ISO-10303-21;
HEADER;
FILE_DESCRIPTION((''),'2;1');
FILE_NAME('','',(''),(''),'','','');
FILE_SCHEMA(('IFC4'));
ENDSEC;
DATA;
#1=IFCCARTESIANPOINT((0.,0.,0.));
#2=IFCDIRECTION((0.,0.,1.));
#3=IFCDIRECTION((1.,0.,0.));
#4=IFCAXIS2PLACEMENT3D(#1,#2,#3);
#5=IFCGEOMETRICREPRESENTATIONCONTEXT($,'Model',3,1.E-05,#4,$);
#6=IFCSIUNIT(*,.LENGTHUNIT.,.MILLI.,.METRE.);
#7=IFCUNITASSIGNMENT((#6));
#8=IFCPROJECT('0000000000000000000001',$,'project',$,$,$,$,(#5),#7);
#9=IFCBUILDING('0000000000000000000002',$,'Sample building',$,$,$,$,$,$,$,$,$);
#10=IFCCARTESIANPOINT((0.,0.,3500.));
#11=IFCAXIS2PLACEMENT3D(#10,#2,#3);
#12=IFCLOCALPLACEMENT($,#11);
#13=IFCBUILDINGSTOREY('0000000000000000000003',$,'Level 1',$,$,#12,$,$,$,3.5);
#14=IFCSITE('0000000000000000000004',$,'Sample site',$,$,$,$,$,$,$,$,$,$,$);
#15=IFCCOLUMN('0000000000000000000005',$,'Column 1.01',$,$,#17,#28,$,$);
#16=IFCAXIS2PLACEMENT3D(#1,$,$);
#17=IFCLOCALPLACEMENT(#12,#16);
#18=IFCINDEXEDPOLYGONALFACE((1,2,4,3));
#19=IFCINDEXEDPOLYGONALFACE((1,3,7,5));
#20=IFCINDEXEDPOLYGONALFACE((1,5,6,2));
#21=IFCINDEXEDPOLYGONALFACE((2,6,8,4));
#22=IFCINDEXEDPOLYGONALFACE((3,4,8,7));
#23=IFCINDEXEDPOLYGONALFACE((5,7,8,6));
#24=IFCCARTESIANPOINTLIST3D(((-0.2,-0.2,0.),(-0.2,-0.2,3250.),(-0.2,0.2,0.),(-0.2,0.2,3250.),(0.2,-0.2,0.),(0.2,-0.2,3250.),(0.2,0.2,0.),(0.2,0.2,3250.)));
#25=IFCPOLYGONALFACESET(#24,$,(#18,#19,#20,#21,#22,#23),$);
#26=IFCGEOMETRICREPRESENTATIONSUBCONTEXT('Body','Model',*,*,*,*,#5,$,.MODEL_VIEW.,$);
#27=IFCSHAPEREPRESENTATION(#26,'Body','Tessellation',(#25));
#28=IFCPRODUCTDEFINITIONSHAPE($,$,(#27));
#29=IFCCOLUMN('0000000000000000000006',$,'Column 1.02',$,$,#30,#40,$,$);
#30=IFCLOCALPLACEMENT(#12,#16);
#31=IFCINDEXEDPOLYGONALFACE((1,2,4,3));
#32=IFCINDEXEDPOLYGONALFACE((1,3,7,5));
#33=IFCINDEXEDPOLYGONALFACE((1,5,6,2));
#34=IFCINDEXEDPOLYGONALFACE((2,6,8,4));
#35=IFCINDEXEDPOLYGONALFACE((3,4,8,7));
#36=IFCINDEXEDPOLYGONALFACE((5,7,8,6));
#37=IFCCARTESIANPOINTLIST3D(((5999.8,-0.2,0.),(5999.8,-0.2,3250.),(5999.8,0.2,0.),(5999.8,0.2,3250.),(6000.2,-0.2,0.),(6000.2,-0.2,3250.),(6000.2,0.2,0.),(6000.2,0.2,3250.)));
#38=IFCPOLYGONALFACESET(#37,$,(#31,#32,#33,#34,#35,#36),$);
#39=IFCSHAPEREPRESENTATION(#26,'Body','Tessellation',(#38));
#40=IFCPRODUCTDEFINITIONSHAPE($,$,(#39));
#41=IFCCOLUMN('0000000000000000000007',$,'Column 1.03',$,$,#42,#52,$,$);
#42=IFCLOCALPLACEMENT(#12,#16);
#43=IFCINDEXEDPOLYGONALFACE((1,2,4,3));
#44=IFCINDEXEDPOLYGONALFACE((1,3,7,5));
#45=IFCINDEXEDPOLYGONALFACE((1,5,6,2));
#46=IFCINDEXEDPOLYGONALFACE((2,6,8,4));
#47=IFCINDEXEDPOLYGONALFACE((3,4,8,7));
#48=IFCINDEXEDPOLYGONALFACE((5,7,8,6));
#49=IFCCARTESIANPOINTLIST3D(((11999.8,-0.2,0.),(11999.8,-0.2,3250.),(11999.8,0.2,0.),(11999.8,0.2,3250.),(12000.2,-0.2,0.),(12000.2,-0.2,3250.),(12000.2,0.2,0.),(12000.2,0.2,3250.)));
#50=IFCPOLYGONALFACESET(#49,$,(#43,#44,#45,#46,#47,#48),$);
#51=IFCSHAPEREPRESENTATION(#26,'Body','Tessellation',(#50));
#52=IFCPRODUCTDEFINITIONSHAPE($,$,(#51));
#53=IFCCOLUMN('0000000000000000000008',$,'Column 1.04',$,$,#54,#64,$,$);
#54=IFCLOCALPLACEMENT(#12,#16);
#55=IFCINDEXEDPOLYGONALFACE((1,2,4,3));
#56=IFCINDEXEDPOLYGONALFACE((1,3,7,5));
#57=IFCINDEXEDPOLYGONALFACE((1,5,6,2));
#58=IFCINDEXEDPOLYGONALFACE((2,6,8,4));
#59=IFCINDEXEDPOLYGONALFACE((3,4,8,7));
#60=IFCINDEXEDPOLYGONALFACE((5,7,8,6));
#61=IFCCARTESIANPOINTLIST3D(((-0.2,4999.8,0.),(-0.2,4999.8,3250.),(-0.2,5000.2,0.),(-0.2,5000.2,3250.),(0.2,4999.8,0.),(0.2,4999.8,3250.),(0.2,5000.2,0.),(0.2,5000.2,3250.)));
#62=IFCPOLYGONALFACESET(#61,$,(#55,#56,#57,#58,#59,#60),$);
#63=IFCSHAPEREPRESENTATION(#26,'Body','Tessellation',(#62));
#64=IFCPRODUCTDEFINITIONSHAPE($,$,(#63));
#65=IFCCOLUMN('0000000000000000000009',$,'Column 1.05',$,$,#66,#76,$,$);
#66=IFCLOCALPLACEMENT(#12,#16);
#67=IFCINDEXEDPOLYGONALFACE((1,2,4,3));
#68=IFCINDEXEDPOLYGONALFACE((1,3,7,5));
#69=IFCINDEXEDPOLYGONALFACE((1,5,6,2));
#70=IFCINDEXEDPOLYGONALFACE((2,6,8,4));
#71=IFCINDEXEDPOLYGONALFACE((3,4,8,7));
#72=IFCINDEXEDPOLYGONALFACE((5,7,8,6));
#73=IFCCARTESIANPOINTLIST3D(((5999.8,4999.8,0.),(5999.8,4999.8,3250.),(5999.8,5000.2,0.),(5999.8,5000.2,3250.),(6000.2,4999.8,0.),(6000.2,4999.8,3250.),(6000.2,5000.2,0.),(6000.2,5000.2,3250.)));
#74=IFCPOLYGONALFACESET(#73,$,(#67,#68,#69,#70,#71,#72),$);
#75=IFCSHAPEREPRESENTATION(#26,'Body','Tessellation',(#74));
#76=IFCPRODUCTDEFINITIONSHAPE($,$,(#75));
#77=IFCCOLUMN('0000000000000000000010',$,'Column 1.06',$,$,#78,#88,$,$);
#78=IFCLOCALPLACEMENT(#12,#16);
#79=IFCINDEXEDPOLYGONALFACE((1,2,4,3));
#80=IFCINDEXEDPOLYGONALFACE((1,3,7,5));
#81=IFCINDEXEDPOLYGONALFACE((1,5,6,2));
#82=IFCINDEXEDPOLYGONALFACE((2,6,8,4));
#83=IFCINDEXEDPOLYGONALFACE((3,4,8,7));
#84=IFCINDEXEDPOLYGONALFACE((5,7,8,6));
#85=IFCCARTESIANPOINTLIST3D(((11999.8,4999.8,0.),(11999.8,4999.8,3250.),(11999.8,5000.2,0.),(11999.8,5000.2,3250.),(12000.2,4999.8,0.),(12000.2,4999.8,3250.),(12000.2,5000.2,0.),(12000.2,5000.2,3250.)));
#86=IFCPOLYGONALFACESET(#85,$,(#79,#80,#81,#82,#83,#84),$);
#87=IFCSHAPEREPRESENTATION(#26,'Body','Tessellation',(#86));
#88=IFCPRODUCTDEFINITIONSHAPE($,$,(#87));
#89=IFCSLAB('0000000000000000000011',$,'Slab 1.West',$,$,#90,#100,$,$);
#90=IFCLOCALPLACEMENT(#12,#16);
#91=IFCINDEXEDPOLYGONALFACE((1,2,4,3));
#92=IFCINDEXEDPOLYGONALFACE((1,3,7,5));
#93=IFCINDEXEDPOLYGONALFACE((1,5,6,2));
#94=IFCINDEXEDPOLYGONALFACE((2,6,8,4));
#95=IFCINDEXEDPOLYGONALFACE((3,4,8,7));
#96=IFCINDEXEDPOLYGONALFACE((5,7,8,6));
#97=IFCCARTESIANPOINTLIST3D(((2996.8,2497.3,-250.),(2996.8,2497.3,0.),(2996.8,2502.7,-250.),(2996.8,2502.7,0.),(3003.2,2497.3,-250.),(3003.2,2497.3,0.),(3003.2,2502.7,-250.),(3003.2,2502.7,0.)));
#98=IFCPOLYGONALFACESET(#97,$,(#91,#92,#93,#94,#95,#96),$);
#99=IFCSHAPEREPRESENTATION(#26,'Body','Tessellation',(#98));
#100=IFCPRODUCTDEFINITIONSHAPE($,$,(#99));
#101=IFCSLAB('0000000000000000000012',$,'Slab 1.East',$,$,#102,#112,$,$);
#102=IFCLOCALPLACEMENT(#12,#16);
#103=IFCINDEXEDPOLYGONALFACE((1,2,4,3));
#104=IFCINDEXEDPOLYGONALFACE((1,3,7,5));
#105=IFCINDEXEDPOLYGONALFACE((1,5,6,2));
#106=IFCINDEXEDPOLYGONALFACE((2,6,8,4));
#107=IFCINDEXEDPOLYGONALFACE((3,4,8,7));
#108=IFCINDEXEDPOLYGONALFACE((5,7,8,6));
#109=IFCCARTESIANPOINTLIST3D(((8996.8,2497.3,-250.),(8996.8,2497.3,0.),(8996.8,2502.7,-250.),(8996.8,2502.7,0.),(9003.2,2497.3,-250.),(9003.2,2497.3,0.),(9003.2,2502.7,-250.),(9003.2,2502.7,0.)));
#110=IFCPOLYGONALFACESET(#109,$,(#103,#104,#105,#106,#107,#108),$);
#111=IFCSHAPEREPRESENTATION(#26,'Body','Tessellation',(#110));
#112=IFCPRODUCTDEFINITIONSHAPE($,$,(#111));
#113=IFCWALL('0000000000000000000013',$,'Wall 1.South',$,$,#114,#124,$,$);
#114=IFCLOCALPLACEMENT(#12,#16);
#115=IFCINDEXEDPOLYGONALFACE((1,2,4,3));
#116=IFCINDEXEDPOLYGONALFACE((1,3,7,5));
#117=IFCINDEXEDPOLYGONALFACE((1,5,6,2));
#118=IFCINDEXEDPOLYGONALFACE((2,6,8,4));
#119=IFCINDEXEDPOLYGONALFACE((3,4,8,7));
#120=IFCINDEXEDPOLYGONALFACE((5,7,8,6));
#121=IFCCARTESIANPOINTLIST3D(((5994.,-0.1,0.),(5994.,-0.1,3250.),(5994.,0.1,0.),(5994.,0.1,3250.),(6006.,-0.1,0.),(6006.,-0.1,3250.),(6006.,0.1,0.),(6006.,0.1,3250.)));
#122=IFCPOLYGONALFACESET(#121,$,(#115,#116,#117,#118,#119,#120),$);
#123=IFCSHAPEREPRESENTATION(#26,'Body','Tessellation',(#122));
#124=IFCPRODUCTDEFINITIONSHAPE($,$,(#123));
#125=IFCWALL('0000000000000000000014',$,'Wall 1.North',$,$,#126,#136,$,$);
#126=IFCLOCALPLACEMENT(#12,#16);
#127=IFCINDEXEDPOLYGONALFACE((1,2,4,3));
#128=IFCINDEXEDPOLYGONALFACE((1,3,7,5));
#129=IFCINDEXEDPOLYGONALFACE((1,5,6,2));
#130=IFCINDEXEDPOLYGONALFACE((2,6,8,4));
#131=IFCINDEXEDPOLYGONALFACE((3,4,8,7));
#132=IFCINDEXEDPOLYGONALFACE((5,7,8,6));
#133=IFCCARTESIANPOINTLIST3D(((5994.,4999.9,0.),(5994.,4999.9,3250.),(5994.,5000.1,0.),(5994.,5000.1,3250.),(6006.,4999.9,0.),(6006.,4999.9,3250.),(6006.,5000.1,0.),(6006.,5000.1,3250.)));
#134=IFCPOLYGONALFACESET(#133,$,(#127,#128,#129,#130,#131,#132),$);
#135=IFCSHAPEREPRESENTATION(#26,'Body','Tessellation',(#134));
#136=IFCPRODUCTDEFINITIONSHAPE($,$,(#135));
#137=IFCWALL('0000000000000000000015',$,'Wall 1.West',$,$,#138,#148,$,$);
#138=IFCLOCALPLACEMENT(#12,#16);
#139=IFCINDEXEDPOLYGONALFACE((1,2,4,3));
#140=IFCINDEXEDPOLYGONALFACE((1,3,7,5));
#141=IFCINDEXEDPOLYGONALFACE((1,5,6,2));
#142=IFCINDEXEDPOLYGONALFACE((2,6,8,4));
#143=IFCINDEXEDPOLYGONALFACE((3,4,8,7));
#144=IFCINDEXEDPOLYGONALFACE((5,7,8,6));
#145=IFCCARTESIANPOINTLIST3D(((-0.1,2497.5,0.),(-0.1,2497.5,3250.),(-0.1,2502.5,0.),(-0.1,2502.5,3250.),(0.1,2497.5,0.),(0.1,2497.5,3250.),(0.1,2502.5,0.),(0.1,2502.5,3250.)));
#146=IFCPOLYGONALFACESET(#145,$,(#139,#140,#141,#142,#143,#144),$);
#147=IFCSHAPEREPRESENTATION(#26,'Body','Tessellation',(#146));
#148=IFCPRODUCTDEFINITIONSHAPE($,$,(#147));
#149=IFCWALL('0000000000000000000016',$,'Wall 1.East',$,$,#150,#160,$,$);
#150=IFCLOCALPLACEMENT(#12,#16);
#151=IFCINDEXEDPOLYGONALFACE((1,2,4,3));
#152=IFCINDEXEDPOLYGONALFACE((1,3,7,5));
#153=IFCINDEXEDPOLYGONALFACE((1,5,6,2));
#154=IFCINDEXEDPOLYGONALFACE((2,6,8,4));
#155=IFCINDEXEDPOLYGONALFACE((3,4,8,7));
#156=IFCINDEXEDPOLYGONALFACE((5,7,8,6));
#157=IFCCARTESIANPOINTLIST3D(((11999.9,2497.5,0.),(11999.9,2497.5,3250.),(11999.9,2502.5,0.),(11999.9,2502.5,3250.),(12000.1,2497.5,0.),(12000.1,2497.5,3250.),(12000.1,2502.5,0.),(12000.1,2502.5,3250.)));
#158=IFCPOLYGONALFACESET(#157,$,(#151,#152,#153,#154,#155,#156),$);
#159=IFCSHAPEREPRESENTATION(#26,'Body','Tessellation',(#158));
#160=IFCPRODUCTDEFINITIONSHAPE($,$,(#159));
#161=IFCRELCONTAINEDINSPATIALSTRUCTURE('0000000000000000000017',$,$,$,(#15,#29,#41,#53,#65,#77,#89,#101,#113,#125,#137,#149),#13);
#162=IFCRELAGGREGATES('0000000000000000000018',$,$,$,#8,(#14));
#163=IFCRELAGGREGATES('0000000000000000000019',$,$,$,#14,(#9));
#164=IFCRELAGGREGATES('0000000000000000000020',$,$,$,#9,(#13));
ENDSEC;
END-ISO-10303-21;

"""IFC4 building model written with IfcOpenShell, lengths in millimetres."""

from ifc_helpers import new_model, si_unit, frame, origin_with_axes, origin_2d, place, context, subcontext, project, spatial, rectangle, extrude, element, save


model = new_model("IFC4")

# Units and contexts
model_context = context("Model", 3, precision=1e-05, world=origin_with_axes())
body_context = subcontext(model_context, "Body", "Model", "MODEL_VIEW")
ifc_project = project(units=[si_unit("LENGTHUNIT", "METRE", prefix="MILLI")], contexts=[model_context])

# Site, building, storey
site = spatial("IfcSite", under=ifc_project, Name="Sample site")
building = spatial("IfcBuilding", under=site, Name="Sample building")
storey_placement = place(None, frame((0.0, 0.0, 3500.0), z_axis=(0.0, 0.0, 1.0), x_axis=(1.0, 0.0, 0.0)))
storey = spatial("IfcBuildingStorey", under=building, at=storey_placement, Name="Level 1", Elevation=3.5)

# Columns
for number, where, z_axis, x_axis, name in (
    (1, (0.0, 0.0, 0.0), (0.0, 0.0, 1.0), (1.0, 0.0, 0.0), "Column 1.01"),
    (2, (6000.0, 0.0, 0.0), (0.0, 0.0, 1.0), (1.0, 0.0, 0.0), "Column 1.02"),
    (3, (12000.0, 0.0, 0.0), (0.0, 0.0, 1.0), (1.0, 0.0, 0.0), "Column 1.03"),
    (4, (0.0, 5000.0, 0.0), (0.0, 0.0, 1.0), (1.0, 0.0, 0.0), "Column 1.04"),
    (5, (6000.0, 5000.0, 0.0), (0.0, 0.0, 1.0), (1.0, 0.0, 0.0), "Column 1.05"),
    (6, (12000.0, 5000.0, 0.0), (0.0, 0.0, 1.0), (1.0, 0.0, 0.0), "Column 1.06"),
):
    element("IfcColumn", number, at=place(storey_placement, frame(where, z_axis=z_axis, x_axis=x_axis)), inside=storey, Name=name, context=body_context, shape_type="SweptSolid", body=[
        extrude(rectangle(XDim=0.4, YDim=0.4, at=origin_2d()), origin_with_axes(), (0.0, 0.0, 1.0), 3250.0),
    ])

# Slabs
for number, where, z_axis, x_axis, name in (
    (7, (3000.0, 2500.0, -250.0), (0.0, 0.0, 1.0), (1.0, 0.0, 0.0), "Slab 1.West"),
    (8, (9000.0, 2500.0, -250.0), (0.0, 0.0, 1.0), (1.0, 0.0, 0.0), "Slab 1.East"),
):
    element("IfcSlab", number, at=place(storey_placement, frame(where, z_axis=z_axis, x_axis=x_axis)), inside=storey, Name=name, context=body_context, shape_type="SweptSolid", body=[
        extrude(rectangle(XDim=6.4, YDim=5.4, at=origin_2d()), origin_with_axes(), (0.0, 0.0, 1.0), 250.0),
    ])

# Walls
for number, where, z_axis, x_axis, name in (
    (9, (6000.0, 0.0, 0.0), (0.0, 0.0, 1.0), (1.0, 0.0, 0.0), "Wall 1.South"),
    (10, (6000.0, 5000.0, 0.0), (0.0, 0.0, 1.0), (1.0, 0.0, 0.0), "Wall 1.North"),
):
    element("IfcWall", number, at=place(storey_placement, frame(where, z_axis=z_axis, x_axis=x_axis)), inside=storey, Name=name, context=body_context, shape_type="SweptSolid", body=[
        extrude(rectangle(XDim=12.0, YDim=0.2, at=origin_2d()), origin_with_axes(), (0.0, 0.0, 1.0), 3250.0),
    ])
for number, where, z_axis, x_axis, name in (
    (11, (0.0, 2500.0, 0.0), (0.0, 0.0, 1.0), (0.0, 1.0, 0.0), "Wall 1.West"),
    (12, (12000.0, 2500.0, 0.0), (0.0, 0.0, 1.0), (0.0, 1.0, 0.0), "Wall 1.East"),
):
    element("IfcWall", number, at=place(storey_placement, frame(where, z_axis=z_axis, x_axis=x_axis)), inside=storey, Name=name, context=body_context, shape_type="SweptSolid", body=[
        extrude(rectangle(XDim=5.0, YDim=0.2, at=origin_2d()), origin_with_axes(), (0.0, 0.0, 1.0), 3250.0),
    ])

save(model, "model.ifc")
